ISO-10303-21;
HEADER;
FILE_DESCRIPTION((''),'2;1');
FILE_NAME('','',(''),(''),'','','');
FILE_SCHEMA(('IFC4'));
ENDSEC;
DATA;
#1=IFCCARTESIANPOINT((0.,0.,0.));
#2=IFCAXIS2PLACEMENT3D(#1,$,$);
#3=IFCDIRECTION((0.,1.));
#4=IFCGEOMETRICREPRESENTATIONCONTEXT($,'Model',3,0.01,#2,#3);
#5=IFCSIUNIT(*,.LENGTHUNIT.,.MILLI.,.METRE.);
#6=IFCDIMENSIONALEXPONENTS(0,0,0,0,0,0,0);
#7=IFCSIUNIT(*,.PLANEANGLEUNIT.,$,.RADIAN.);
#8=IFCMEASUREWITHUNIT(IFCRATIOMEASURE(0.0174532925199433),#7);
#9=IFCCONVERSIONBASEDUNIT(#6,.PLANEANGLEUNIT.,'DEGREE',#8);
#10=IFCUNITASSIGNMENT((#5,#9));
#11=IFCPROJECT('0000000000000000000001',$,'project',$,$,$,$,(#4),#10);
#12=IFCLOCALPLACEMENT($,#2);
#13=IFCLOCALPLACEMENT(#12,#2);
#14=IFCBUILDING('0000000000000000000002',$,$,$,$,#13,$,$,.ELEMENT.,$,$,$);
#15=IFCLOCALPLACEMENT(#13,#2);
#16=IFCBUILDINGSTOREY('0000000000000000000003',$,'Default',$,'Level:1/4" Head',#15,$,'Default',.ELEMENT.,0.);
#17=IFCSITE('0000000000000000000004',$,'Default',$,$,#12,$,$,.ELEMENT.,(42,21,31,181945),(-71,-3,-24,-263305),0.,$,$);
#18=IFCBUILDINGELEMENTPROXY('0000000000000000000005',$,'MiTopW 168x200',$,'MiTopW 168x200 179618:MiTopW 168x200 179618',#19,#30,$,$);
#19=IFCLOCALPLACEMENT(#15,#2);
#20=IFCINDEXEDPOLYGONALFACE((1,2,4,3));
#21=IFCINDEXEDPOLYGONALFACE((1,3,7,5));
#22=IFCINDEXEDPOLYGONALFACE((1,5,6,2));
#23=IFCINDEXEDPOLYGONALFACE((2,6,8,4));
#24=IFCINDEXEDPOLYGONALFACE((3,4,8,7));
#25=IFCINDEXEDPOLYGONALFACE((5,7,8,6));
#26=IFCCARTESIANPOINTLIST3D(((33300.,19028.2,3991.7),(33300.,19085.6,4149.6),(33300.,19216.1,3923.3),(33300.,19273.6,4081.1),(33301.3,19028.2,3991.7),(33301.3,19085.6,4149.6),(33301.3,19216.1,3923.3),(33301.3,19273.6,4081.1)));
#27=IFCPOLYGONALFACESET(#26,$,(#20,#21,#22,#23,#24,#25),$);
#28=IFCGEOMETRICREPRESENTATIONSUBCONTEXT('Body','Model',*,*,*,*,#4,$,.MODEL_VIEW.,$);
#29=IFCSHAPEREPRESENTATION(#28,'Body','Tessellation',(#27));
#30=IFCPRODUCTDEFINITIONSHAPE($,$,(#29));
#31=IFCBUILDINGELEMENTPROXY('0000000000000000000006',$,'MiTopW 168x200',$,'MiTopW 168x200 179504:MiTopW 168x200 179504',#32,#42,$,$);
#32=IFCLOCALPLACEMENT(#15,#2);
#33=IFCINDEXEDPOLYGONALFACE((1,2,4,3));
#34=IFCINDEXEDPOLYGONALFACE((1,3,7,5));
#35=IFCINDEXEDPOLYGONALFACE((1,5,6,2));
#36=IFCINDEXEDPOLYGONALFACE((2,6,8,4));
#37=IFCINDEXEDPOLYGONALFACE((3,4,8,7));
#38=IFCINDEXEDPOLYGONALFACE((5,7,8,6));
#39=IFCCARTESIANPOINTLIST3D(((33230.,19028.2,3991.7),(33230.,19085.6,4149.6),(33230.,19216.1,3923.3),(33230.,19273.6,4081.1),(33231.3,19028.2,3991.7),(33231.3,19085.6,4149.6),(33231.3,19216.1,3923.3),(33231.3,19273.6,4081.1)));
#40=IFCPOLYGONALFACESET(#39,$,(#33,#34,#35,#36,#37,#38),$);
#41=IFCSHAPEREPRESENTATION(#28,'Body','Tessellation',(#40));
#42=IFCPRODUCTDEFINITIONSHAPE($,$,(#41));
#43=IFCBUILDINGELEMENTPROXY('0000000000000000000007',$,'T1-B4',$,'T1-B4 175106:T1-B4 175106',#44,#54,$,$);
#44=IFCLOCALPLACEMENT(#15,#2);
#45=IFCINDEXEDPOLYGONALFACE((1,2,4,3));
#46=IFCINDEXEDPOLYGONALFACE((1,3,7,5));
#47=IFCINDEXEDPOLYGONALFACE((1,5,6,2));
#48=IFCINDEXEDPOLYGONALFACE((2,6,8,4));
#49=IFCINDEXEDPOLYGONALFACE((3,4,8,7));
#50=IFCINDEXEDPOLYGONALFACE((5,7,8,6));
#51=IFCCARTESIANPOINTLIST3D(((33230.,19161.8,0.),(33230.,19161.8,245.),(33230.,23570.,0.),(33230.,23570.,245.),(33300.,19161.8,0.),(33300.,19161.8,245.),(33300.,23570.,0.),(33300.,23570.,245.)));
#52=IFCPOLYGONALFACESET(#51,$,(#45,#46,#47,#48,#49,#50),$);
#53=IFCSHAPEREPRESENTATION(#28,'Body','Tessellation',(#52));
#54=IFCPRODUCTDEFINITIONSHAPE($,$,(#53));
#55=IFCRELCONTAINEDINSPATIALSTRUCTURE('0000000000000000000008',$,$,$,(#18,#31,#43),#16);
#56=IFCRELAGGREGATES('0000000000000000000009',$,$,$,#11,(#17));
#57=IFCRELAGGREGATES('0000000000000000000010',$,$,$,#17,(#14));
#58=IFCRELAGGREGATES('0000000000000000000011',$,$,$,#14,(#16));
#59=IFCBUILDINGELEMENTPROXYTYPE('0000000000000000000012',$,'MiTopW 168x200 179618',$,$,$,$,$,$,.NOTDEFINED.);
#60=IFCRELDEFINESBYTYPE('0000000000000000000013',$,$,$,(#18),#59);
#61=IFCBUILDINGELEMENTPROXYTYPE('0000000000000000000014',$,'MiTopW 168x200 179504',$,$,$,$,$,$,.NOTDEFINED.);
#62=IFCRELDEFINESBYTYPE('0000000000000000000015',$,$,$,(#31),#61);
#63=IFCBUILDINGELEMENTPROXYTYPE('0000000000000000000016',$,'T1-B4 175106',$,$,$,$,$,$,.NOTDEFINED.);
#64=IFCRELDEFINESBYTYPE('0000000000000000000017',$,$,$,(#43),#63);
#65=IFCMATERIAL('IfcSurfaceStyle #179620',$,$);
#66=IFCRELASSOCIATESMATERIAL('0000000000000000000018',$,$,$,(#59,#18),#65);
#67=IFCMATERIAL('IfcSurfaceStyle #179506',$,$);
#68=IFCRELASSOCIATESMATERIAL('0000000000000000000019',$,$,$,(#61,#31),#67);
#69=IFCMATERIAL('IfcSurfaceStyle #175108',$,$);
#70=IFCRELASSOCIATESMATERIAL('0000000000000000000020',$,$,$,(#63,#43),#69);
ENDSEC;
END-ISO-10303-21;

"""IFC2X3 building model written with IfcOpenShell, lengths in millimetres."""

from ifc_helpers import new_model, entity, si_unit, converted_unit, direction, frame, origin, origin_2d_with_axis, place, context, subcontext, project, spatial, polyline, rectangle, outline, extrude, source, transform, mapped, material, type_object, type_shapes, element, save


model = new_model("IFC2X3")

# Units and contexts
model_context = context("Model", 3, precision=0.01, world=origin(), true_north=direction((0.0, 1.0)))
body_context = subcontext(model_context, "Body", "Model", "MODEL_VIEW")
ifc_project = project(units=[si_unit("LENGTHUNIT", "METRE", prefix="MILLI"), converted_unit("PLANEANGLEUNIT", "DEGREE", entity("IfcRatioMeasure", 0.0174532925199433), si_unit("PLANEANGLEUNIT", "RADIAN"), dimensions=[0, 0, 0, 0, 0, 0, 0])], contexts=[model_context])

# Site, building, storey
site_placement = place(None, origin())
site = spatial("IfcSite", under=ifc_project, at=site_placement, Name="Default", CompositionType="ELEMENT", RefLatitude=(42, 21, 31, 181945), RefLongitude=(-71, -3, -24, -263305), RefElevation=0.0)
building_placement = place(site_placement, origin())
building = spatial("IfcBuilding", under=site, at=building_placement, CompositionType="ELEMENT")
storey_placement = place(building_placement, origin())
storey = spatial("IfcBuildingStorey", under=building, at=storey_placement, Name="Default", ObjectType="Level:1/4\" Head", LongName="Default", CompositionType="ELEMENT", Elevation=0.0)

# Building element proxies
ifc_material_1 = material(Name="IfcSurfaceStyle #179620")
building_element_proxy_type_1 = type_object("IfcBuildingElementProxyType", Name="MiTopW 168x200 179618", PredefinedType="NOTDEFINED", material=ifc_material_1)
shared_shape_1 = source(origin(), body_context, "Body", "SweptSolid", [
    extrude(outline(polyline([(-100.0, -84.0), (100.0, -84.0), (100.0, 84.0), (-100.0, 84.0), (-100.0, -84.0)])), frame((100.0, 84.0, 0.0), z_axis=(0.0, 0.0, 1.0), x_axis=(-1.0, 0.0, 0.0)), (0.0, 0.0, 1.0), 1.3),
])
type_shapes(building_element_proxy_type_1, [shared_shape_1])
proxy_1_placement = place(building_placement, frame((33301.3, 19216.1, 3923.3), z_axis=(-1.0, 0.0, 0.0), x_axis=(0.0, -0.939693, 0.34202)))
element("IfcBuildingElementProxy", 1, at=proxy_1_placement, inside=storey, type_object=building_element_proxy_type_1, material=ifc_material_1, Name="MiTopW 168x200", ObjectType="MiTopW 168x200 179618:MiTopW 168x200 179618", context=body_context, shape_type="MappedRepresentation", body=[
    mapped(shared_shape_1, transform((0.0, 0.0, 0.0), scale=1.0)),
])
ifc_material_2 = material(Name="IfcSurfaceStyle #179506")
building_element_proxy_type_2 = type_object("IfcBuildingElementProxyType", Name="MiTopW 168x200 179504", PredefinedType="NOTDEFINED", material=ifc_material_2)
shared_shape_2 = source(origin(), body_context, "Body", "SweptSolid", [
    extrude(outline(polyline([(-100.0, -84.0), (100.0, -84.0), (100.0, 84.0), (-100.0, 84.0), (-100.0, -84.0)])), frame((100.0, 84.0, 0.0), z_axis=(0.0, 0.0, 1.0), x_axis=(-1.0, 0.0, 0.0)), (0.0, 0.0, 1.0), 1.3),
])
type_shapes(building_element_proxy_type_2, [shared_shape_2])
proxy_2_placement = place(building_placement, frame((33231.3, 19216.1, 3923.3), z_axis=(-1.0, 0.0, 0.0), x_axis=(0.0, -0.939693, 0.34202)))
element("IfcBuildingElementProxy", 2, at=proxy_2_placement, inside=storey, type_object=building_element_proxy_type_2, material=ifc_material_2, Name="MiTopW 168x200", ObjectType="MiTopW 168x200 179504:MiTopW 168x200 179504", context=body_context, shape_type="MappedRepresentation", body=[
    mapped(shared_shape_2, transform((0.0, 0.0, 0.0), scale=1.0)),
])
ifc_material_3 = material(Name="IfcSurfaceStyle #175108")
building_element_proxy_type_3 = type_object("IfcBuildingElementProxyType", Name="T1-B4 175106", PredefinedType="NOTDEFINED", material=ifc_material_3)
shared_shape_3 = source(origin(), body_context, "Body", "SweptSolid", [
    extrude(rectangle(XDim=4408.2, YDim=245.0, at=origin_2d_with_axis()), frame((2204.1, 122.5, 0.0), z_axis=(0.0, 0.0, 1.0), x_axis=(-1.0, 0.0, 0.0)), (0.0, 0.0, 1.0), 70.0),
])
type_shapes(building_element_proxy_type_3, [shared_shape_3])
proxy_3_placement = place(building_placement, frame((33300.0, 19161.8, 245.0), z_axis=(-1.0, 0.0, 0.0), x_axis=(0.0, 1.0, 0.0)))
element("IfcBuildingElementProxy", 3, at=proxy_3_placement, inside=storey, type_object=building_element_proxy_type_3, material=ifc_material_3, Name="T1-B4", ObjectType="T1-B4 175106:T1-B4 175106", context=body_context, shape_type="MappedRepresentation", body=[
    mapped(shared_shape_3, transform((0.0, 0.0, 0.0), scale=1.0)),
])

save(model, "model.ifc")
